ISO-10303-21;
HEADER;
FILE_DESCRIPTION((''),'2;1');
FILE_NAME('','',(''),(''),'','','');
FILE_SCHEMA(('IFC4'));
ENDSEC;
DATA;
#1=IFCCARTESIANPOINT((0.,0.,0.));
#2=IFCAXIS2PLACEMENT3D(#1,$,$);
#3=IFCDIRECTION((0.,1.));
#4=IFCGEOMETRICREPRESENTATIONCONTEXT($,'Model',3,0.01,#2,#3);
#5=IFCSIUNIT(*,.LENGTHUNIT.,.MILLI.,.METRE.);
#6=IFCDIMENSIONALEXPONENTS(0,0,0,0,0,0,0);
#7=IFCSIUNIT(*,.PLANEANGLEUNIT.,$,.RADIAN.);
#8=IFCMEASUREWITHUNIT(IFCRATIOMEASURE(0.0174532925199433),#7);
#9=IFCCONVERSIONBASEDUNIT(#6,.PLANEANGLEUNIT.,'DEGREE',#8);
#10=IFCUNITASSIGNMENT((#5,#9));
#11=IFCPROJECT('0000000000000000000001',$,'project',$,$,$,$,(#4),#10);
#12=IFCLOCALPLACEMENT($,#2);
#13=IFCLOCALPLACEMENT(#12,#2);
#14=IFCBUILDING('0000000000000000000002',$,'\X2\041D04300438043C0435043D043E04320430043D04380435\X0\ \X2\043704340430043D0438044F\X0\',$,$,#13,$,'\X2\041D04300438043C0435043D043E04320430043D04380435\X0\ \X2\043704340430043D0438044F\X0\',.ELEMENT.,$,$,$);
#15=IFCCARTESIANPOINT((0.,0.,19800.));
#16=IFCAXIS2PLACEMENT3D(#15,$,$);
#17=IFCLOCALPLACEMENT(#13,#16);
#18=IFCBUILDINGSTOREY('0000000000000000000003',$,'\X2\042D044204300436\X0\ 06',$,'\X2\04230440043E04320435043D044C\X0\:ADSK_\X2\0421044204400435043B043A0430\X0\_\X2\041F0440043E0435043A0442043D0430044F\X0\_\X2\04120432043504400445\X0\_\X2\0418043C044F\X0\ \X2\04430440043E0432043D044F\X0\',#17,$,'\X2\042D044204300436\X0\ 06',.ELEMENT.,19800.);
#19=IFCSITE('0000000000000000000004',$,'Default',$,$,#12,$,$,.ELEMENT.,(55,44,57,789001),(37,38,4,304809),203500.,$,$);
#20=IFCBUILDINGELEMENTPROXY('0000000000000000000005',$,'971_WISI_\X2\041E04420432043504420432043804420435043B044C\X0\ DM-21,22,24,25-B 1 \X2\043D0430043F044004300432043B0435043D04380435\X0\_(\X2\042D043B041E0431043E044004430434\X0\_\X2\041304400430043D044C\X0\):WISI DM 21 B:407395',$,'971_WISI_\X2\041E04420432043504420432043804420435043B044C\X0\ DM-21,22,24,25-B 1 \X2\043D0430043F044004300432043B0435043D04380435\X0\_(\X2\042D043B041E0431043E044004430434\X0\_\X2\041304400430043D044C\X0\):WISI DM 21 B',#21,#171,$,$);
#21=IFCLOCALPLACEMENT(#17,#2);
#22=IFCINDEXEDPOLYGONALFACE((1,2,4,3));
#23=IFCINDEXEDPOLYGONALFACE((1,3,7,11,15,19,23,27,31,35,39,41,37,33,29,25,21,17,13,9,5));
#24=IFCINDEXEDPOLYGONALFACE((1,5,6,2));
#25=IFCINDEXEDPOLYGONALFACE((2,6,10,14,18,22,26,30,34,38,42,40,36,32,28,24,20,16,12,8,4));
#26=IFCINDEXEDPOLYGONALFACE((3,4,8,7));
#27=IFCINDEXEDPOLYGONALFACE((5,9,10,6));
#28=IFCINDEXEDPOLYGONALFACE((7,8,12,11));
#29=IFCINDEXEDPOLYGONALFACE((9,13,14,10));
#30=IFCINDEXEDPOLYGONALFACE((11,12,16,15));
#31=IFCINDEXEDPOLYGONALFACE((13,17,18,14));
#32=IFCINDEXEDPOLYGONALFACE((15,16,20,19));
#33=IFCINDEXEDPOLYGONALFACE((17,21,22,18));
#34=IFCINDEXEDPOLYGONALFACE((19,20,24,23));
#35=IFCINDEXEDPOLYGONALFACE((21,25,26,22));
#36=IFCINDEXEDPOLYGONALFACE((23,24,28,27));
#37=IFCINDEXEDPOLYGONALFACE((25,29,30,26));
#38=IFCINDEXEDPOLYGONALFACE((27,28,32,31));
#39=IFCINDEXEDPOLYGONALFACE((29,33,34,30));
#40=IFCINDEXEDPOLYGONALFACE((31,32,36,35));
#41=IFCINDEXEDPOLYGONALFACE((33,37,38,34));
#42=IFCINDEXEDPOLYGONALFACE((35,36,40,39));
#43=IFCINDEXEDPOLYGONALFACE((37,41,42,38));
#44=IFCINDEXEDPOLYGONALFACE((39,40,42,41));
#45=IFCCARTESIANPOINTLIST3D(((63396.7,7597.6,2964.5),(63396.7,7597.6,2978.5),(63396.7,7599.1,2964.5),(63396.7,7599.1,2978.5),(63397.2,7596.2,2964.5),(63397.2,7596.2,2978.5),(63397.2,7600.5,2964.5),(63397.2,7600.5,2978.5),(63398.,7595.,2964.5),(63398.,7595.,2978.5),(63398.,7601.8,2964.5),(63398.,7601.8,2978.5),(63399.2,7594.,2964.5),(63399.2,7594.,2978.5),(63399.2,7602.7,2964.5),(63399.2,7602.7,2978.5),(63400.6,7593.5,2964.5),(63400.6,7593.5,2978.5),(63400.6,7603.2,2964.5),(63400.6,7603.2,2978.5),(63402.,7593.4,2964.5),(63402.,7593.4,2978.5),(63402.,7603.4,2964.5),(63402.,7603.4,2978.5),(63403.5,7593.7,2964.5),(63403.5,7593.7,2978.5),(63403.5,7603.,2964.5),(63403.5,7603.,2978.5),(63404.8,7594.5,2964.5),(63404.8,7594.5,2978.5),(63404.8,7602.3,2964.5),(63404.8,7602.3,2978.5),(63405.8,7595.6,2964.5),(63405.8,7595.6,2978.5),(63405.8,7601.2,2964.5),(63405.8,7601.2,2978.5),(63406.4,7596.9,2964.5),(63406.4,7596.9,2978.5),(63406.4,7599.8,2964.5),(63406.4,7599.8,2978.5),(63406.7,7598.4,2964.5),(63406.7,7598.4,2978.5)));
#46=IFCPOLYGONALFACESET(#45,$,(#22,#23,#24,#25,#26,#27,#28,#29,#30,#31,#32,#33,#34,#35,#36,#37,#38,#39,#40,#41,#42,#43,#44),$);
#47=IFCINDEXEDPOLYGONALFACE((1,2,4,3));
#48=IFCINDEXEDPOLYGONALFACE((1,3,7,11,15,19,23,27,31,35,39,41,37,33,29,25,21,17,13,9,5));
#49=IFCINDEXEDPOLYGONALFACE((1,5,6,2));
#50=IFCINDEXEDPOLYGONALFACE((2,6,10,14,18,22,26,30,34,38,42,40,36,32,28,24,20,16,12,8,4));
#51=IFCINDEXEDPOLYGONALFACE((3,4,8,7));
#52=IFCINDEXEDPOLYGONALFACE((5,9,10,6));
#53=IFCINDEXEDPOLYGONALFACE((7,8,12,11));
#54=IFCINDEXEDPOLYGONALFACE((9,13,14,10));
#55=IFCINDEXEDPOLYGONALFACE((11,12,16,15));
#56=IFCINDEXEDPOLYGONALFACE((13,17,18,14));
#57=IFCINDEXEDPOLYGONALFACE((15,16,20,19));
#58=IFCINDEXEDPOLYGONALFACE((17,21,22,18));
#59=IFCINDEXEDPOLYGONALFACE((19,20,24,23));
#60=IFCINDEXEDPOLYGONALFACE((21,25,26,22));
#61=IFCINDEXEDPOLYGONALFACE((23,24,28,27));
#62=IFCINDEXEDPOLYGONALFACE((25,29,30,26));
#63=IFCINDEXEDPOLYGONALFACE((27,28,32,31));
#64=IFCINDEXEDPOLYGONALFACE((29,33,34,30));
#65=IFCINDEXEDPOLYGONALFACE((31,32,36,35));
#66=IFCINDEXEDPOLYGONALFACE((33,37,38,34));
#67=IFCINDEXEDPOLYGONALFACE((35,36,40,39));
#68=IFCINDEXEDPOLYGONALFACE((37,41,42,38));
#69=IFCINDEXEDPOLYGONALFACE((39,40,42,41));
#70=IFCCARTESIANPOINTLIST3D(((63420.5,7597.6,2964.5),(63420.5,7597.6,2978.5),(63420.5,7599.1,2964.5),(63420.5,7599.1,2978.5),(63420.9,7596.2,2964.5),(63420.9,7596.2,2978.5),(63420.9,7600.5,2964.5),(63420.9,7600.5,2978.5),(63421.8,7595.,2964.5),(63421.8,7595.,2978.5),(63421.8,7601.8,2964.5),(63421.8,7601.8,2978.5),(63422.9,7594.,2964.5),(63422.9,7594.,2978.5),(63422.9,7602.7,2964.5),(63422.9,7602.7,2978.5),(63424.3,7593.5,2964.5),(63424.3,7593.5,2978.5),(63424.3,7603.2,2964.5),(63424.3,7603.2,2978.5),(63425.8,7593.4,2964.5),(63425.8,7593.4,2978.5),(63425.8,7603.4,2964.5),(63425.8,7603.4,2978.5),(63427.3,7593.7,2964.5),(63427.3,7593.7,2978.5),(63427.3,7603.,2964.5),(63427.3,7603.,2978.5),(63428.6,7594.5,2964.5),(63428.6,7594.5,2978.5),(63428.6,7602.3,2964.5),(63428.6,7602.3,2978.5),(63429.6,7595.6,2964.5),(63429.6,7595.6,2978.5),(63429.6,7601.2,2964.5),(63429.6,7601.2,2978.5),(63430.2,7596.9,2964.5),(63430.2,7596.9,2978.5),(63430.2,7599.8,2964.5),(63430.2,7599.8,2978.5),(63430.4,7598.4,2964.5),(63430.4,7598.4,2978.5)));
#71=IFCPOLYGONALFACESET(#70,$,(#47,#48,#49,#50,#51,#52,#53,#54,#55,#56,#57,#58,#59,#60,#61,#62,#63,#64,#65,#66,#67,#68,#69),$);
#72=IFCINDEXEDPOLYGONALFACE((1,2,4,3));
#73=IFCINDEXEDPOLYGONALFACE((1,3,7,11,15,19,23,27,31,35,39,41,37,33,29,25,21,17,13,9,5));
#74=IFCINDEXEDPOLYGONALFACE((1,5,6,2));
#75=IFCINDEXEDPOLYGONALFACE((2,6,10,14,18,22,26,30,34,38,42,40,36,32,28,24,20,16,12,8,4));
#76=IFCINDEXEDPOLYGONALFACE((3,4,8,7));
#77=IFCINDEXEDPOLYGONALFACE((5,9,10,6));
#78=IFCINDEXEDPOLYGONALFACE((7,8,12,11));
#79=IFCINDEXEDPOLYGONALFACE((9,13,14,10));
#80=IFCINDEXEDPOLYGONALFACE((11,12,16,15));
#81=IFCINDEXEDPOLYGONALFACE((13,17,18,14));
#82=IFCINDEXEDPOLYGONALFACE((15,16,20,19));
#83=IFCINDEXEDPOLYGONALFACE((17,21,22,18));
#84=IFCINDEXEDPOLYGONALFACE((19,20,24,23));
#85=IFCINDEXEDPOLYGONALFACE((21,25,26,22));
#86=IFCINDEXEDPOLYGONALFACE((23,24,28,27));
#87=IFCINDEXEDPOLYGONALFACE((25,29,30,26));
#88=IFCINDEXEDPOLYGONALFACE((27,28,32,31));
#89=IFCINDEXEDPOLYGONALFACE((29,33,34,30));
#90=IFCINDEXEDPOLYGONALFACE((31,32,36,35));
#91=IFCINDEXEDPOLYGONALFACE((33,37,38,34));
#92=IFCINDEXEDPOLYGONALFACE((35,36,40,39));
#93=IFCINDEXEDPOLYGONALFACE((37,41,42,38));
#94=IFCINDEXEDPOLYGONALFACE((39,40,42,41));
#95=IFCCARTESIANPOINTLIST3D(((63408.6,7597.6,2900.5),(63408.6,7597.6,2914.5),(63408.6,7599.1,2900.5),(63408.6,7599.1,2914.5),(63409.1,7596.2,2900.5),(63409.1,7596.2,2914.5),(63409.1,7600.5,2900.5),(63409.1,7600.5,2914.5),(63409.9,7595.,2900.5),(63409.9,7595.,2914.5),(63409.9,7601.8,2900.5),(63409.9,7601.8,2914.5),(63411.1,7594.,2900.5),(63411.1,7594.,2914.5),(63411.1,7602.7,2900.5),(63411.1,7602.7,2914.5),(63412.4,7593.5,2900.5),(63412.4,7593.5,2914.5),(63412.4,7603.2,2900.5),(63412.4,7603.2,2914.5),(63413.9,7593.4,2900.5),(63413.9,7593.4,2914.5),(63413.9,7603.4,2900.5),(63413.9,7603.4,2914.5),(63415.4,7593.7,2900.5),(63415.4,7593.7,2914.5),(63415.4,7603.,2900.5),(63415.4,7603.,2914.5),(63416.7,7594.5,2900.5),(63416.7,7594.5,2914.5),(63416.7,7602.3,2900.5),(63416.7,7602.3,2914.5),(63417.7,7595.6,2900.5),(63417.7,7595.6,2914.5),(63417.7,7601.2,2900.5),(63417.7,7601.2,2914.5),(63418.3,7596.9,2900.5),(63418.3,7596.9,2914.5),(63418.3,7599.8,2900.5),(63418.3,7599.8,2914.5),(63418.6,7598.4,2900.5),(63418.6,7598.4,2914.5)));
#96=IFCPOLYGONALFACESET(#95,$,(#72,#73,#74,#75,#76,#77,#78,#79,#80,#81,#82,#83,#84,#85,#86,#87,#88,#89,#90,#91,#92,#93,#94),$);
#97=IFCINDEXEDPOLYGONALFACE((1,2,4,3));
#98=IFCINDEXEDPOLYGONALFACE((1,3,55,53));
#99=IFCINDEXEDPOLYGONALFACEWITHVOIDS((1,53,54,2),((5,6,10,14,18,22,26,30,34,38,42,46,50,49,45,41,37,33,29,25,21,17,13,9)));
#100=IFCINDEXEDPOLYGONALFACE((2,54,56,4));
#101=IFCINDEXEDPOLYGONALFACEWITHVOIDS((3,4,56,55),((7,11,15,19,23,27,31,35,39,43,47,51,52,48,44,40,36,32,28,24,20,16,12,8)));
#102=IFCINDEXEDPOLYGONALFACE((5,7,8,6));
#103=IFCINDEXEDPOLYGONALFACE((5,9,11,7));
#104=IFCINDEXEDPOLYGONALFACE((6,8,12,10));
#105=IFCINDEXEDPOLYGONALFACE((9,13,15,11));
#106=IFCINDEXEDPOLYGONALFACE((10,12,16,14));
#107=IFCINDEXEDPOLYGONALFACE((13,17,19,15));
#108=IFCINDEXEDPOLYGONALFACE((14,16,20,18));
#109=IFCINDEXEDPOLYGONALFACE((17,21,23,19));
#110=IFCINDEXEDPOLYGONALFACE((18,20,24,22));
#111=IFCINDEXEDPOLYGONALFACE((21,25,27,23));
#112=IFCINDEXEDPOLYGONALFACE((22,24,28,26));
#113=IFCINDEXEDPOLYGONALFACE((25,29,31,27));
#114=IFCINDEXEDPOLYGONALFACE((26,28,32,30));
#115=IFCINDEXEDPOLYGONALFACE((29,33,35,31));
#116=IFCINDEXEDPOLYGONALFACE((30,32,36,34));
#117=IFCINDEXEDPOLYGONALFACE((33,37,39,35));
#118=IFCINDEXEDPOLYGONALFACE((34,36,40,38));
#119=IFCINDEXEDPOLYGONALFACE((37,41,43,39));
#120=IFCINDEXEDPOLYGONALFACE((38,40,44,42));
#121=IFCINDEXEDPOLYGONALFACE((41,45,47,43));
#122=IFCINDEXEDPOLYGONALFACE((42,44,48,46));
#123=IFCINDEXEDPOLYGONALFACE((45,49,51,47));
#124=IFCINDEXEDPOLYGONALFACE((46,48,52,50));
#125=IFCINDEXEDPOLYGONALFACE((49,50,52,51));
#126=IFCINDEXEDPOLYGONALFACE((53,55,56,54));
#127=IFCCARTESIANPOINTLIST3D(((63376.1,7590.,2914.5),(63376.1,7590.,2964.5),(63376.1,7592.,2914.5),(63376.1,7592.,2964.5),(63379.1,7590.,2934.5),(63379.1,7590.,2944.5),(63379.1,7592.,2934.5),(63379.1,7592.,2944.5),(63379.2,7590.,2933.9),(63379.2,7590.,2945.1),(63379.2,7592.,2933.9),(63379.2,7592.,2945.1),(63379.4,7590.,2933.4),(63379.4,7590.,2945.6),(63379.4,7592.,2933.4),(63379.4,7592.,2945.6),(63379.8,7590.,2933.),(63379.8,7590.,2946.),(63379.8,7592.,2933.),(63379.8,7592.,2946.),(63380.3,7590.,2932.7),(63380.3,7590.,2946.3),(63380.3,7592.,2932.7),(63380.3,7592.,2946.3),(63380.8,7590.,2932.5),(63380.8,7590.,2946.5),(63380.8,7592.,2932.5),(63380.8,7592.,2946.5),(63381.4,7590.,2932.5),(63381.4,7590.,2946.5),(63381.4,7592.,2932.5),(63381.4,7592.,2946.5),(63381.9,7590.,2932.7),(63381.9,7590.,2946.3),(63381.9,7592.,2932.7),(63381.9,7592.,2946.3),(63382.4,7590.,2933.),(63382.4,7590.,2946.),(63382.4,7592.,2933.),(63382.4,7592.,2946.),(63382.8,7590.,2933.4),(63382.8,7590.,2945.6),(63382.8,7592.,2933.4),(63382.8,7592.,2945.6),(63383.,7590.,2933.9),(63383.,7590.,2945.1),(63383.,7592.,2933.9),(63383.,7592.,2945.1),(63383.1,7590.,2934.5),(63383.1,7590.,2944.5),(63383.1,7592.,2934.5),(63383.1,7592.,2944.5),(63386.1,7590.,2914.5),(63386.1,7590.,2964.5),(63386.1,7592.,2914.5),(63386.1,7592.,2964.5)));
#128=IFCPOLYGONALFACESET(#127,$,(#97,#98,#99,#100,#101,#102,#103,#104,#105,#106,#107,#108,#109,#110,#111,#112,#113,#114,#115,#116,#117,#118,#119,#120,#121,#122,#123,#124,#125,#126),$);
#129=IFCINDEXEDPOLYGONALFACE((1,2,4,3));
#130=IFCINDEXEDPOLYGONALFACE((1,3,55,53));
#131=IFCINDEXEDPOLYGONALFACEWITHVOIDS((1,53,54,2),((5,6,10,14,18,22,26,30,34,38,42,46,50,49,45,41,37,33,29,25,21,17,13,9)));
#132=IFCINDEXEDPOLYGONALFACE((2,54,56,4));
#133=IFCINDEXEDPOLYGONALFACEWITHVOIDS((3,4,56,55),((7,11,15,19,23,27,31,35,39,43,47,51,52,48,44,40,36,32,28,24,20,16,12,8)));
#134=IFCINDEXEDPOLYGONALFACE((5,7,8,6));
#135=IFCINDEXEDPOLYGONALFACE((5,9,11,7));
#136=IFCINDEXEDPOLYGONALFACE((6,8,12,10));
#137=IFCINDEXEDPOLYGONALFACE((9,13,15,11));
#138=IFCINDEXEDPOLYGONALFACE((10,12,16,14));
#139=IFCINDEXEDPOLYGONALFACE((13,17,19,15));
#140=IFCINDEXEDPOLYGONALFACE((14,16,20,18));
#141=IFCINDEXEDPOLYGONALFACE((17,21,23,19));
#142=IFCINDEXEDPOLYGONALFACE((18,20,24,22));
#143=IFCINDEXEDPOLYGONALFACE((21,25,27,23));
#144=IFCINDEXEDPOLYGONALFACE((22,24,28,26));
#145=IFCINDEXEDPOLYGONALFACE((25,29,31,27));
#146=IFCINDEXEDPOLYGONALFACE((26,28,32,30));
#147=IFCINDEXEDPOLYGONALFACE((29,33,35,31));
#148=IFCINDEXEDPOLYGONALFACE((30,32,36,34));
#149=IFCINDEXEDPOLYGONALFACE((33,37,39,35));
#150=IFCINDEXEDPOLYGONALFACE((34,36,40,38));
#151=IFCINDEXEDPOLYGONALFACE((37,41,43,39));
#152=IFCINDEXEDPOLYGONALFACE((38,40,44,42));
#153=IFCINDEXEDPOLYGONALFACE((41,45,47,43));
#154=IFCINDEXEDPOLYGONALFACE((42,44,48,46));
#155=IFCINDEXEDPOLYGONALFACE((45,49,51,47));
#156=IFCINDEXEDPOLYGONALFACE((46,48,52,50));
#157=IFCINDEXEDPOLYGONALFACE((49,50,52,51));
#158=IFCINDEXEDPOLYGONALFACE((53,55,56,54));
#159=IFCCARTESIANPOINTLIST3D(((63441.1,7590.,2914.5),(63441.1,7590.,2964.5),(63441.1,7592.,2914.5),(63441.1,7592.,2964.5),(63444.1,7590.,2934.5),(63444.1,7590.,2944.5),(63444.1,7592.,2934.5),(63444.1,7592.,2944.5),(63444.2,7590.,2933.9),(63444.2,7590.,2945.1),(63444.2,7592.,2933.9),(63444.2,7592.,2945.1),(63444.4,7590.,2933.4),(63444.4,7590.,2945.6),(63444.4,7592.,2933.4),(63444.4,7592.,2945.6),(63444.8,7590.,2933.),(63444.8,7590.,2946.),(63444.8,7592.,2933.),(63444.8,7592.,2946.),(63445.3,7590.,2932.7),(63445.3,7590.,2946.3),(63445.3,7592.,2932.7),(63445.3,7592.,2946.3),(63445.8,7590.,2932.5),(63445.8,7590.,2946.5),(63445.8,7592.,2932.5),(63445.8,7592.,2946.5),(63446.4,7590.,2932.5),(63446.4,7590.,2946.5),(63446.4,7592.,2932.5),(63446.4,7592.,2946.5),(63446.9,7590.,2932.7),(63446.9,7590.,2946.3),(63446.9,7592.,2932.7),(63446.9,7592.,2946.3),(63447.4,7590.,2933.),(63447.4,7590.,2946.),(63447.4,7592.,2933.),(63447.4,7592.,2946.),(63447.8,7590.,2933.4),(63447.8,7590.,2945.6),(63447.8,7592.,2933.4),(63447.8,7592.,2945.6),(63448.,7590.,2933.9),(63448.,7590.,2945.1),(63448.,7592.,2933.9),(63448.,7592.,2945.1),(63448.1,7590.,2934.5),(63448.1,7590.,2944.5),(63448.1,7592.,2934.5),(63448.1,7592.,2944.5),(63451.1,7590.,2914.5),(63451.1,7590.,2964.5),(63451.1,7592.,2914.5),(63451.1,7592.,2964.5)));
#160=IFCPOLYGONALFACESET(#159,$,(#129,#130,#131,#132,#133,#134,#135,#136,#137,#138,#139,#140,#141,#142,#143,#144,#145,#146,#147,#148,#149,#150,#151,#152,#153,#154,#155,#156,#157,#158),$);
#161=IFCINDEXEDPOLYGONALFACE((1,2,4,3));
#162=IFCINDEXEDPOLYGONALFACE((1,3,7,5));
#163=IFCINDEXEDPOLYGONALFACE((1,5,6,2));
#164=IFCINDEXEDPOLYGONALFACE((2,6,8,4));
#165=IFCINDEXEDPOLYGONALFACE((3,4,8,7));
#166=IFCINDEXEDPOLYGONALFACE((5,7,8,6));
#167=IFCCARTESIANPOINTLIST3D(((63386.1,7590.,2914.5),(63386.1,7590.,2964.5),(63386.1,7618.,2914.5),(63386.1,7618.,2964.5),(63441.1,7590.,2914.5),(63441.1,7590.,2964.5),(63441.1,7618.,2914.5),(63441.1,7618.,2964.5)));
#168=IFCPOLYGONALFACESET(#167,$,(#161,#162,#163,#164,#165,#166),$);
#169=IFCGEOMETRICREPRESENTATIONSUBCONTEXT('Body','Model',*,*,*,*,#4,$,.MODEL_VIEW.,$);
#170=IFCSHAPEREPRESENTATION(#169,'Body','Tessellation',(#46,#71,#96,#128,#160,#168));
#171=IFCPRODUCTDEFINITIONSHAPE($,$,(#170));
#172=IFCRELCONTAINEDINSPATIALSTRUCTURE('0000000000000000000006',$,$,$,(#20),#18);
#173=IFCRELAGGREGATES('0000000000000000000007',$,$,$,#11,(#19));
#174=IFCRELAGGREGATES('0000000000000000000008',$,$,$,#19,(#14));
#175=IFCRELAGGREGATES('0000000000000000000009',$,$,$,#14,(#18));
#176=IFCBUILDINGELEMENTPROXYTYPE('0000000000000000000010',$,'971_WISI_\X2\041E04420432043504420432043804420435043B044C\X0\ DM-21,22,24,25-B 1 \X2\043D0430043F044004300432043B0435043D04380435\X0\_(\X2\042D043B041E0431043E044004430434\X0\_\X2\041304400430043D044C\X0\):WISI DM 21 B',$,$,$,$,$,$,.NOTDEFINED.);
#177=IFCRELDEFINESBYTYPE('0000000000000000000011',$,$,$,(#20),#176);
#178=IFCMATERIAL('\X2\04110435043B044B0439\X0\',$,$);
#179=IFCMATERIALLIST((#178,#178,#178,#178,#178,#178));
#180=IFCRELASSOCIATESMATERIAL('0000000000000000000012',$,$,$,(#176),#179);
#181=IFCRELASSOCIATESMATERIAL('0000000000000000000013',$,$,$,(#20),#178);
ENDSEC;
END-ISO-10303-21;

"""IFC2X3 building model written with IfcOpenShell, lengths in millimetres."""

from ifc_helpers import new_model, entity, si_unit, converted_unit, direction, frame, frame_2d, origin, place, context, subcontext, project, spatial, polyline, circle_curve, parameter, trimmed, segment, composite_curve, rectangle, circle, outline, extrude, source, transform, mapped, material, material_list, type_object, type_shapes, element, save


model = new_model("IFC2X3")

# Units and contexts
model_context = context("Model", 3, precision=0.01, world=origin(), true_north=direction((0.0, 1.0)))
body_context = subcontext(model_context, "Body", "Model", "MODEL_VIEW")
ifc_project = project(units=[si_unit("LENGTHUNIT", "METRE", prefix="MILLI"), converted_unit("PLANEANGLEUNIT", "DEGREE", entity("IfcRatioMeasure", 0.0174532925199433), si_unit("PLANEANGLEUNIT", "RADIAN"), dimensions=[0, 0, 0, 0, 0, 0, 0])], contexts=[model_context])

# Site, building, storey
site_placement = place(None, frame((0.0, 0.0, 0.0)))
site = spatial("IfcSite", under=ifc_project, at=site_placement, Name="Default", CompositionType="ELEMENT", RefLatitude=(55, 44, 57, 789001), RefLongitude=(37, 38, 4, 304809), RefElevation=203500.0)
building_placement = place(site_placement, origin())
building = spatial("IfcBuilding", under=site, at=building_placement, Name="Наименование здания", LongName="Наименование здания", CompositionType="ELEMENT")
storey_placement = place(building_placement, frame((0.0, 0.0, 19800.0)))
storey = spatial("IfcBuildingStorey", under=building, at=storey_placement, Name="Этаж 06", ObjectType="Уровень:ADSK_Стрелка_Проектная_Вверх_Имя уровня", LongName="Этаж 06", CompositionType="ELEMENT", Elevation=19800.0)

# Building element proxy
ifc_material_1 = material(Name="Белый")
ifc_material_list_1 = material_list([ifc_material_1, ifc_material_1, ifc_material_1, ifc_material_1, ifc_material_1, ifc_material_1])
building_element_proxy_type_1 = type_object("IfcBuildingElementProxyType", Name="971_WISI_Ответвитель DM-21,22,24,25-B 1 направление_(ЭлОборуд_Грань):WISI DM 21 B", PredefinedType="NOTDEFINED", material=ifc_material_list_1)
shared_shape_1 = source(origin(), body_context, "Body", "SweptSolid", [
    extrude(circle(Radius=5.0, at=frame_2d((0.0, 0.0), x_axis=(1.0, 0.0))), frame((11.9, 25.0, 8.4), z_axis=(0.0, 1.0, 0.0), x_axis=(-1.0, 0.0, 0.0)), (0.0, 0.0, 1.0), 14.0),
    extrude(circle(Radius=5.0, at=frame_2d((0.0, 0.0), x_axis=(1.0, 0.0))), frame((-11.8, 25.0, 8.4), z_axis=(0.0, 1.0, 0.0), x_axis=(-1.0, 0.0, 0.0)), (0.0, 0.0, 1.0), 14.0),
    extrude(circle(Radius=5.0, at=frame_2d((0.0, 0.0), x_axis=(1.0, 0.0))), frame((0.0, -39.0, 8.4), z_axis=(0.0, 1.0, 0.0), x_axis=(-1.0, 0.0, 0.0)), (0.0, 0.0, 1.0), 14.0),
    extrude(outline(polyline([(-5.0, -25.0), (5.0, -25.0), (5.0, 25.0), (-5.0, 25.0), (-5.0, -25.0)]), holes=[composite_curve([segment(polyline([(2.0, 5.0), (2.0, -5.0)]), True, "CONTINUOUS"), segment(trimmed(circle_curve(frame_2d((0.0, -5.0), x_axis=(-1.0, 0.0)), 2.0), [parameter(0.0)], [parameter(180.0)], True, "PARAMETER"), False, "CONTINUOUS"), segment(polyline([(-2.0, -5.0), (-2.0, 5.0)]), True, "CONTINUOUS"), segment(trimmed(circle_curve(frame_2d((0.0, 5.0), x_axis=(-1.0, 0.0)), 2.0), [parameter(180.0)], [parameter(0.0)], True, "PARAMETER"), False, "CONTINUOUS")], self_intersect=False)]), frame((32.5, 0.0, 0.0), z_axis=(0.0, 0.0, 1.0), x_axis=(-1.0, 0.0, 0.0)), (0.0, 0.0, 1.0), 2.0),
    extrude(outline(polyline([(-5.0, -25.0), (5.0, -25.0), (5.0, 25.0), (-5.0, 25.0), (-5.0, -25.0)]), holes=[composite_curve([segment(polyline([(-2.0, -5.0), (-2.0, 5.0)]), True, "CONTINUOUS"), segment(trimmed(circle_curve(frame_2d((0.0, 5.0), x_axis=(-1.0, 0.0)), 2.0), [parameter(180.0)], [parameter(0.0)], True, "PARAMETER"), False, "CONTINUOUS"), segment(polyline([(2.0, 5.0), (2.0, -5.0)]), True, "CONTINUOUS"), segment(trimmed(circle_curve(frame_2d((0.0, -5.0), x_axis=(-1.0, 0.0)), 2.0), [parameter(0.0)], [parameter(180.0)], True, "PARAMETER"), False, "CONTINUOUS")], self_intersect=False)]), frame((-32.5, 0.0, 0.0), z_axis=(0.0, 0.0, 1.0), x_axis=(-1.0, 0.0, 0.0)), (0.0, 0.0, 1.0), 2.0),
    extrude(rectangle(XDim=55.0, YDim=50.0, at=frame_2d((0.0, 0.0), x_axis=(1.0, 0.0))), frame((0.0, 0.0, 0.0), z_axis=(0.0, 0.0, 1.0), x_axis=(-1.0, 0.0, 0.0)), (0.0, 0.0, 1.0), 28.0),
])
type_shapes(building_element_proxy_type_1, [shared_shape_1])
for number, where, z_axis, x_axis, name in (
    (1, (63413.6, 7590.0, 2939.5), (0.0, 1.0, 0.0), (-1.0, 0.0, 0.0), "971_WISI_Ответвитель DM-21,22,24,25-B 1 направление_(ЭлОборуд_Грань):WISI DM 21 B:407395"),
):
    element("IfcBuildingElementProxy", number, at=place(storey_placement, frame(where, z_axis=z_axis, x_axis=x_axis)), inside=storey, type_object=building_element_proxy_type_1, material=ifc_material_1, Name=name, ObjectType="971_WISI_Ответвитель DM-21,22,24,25-B 1 направление_(ЭлОборуд_Грань):WISI DM 21 B", context=body_context, shape_type="MappedRepresentation", body=[
        mapped(shared_shape_1, transform((0.0, 0.0, 0.0), scale=1.0)),
    ])

save(model, "model.ifc")
